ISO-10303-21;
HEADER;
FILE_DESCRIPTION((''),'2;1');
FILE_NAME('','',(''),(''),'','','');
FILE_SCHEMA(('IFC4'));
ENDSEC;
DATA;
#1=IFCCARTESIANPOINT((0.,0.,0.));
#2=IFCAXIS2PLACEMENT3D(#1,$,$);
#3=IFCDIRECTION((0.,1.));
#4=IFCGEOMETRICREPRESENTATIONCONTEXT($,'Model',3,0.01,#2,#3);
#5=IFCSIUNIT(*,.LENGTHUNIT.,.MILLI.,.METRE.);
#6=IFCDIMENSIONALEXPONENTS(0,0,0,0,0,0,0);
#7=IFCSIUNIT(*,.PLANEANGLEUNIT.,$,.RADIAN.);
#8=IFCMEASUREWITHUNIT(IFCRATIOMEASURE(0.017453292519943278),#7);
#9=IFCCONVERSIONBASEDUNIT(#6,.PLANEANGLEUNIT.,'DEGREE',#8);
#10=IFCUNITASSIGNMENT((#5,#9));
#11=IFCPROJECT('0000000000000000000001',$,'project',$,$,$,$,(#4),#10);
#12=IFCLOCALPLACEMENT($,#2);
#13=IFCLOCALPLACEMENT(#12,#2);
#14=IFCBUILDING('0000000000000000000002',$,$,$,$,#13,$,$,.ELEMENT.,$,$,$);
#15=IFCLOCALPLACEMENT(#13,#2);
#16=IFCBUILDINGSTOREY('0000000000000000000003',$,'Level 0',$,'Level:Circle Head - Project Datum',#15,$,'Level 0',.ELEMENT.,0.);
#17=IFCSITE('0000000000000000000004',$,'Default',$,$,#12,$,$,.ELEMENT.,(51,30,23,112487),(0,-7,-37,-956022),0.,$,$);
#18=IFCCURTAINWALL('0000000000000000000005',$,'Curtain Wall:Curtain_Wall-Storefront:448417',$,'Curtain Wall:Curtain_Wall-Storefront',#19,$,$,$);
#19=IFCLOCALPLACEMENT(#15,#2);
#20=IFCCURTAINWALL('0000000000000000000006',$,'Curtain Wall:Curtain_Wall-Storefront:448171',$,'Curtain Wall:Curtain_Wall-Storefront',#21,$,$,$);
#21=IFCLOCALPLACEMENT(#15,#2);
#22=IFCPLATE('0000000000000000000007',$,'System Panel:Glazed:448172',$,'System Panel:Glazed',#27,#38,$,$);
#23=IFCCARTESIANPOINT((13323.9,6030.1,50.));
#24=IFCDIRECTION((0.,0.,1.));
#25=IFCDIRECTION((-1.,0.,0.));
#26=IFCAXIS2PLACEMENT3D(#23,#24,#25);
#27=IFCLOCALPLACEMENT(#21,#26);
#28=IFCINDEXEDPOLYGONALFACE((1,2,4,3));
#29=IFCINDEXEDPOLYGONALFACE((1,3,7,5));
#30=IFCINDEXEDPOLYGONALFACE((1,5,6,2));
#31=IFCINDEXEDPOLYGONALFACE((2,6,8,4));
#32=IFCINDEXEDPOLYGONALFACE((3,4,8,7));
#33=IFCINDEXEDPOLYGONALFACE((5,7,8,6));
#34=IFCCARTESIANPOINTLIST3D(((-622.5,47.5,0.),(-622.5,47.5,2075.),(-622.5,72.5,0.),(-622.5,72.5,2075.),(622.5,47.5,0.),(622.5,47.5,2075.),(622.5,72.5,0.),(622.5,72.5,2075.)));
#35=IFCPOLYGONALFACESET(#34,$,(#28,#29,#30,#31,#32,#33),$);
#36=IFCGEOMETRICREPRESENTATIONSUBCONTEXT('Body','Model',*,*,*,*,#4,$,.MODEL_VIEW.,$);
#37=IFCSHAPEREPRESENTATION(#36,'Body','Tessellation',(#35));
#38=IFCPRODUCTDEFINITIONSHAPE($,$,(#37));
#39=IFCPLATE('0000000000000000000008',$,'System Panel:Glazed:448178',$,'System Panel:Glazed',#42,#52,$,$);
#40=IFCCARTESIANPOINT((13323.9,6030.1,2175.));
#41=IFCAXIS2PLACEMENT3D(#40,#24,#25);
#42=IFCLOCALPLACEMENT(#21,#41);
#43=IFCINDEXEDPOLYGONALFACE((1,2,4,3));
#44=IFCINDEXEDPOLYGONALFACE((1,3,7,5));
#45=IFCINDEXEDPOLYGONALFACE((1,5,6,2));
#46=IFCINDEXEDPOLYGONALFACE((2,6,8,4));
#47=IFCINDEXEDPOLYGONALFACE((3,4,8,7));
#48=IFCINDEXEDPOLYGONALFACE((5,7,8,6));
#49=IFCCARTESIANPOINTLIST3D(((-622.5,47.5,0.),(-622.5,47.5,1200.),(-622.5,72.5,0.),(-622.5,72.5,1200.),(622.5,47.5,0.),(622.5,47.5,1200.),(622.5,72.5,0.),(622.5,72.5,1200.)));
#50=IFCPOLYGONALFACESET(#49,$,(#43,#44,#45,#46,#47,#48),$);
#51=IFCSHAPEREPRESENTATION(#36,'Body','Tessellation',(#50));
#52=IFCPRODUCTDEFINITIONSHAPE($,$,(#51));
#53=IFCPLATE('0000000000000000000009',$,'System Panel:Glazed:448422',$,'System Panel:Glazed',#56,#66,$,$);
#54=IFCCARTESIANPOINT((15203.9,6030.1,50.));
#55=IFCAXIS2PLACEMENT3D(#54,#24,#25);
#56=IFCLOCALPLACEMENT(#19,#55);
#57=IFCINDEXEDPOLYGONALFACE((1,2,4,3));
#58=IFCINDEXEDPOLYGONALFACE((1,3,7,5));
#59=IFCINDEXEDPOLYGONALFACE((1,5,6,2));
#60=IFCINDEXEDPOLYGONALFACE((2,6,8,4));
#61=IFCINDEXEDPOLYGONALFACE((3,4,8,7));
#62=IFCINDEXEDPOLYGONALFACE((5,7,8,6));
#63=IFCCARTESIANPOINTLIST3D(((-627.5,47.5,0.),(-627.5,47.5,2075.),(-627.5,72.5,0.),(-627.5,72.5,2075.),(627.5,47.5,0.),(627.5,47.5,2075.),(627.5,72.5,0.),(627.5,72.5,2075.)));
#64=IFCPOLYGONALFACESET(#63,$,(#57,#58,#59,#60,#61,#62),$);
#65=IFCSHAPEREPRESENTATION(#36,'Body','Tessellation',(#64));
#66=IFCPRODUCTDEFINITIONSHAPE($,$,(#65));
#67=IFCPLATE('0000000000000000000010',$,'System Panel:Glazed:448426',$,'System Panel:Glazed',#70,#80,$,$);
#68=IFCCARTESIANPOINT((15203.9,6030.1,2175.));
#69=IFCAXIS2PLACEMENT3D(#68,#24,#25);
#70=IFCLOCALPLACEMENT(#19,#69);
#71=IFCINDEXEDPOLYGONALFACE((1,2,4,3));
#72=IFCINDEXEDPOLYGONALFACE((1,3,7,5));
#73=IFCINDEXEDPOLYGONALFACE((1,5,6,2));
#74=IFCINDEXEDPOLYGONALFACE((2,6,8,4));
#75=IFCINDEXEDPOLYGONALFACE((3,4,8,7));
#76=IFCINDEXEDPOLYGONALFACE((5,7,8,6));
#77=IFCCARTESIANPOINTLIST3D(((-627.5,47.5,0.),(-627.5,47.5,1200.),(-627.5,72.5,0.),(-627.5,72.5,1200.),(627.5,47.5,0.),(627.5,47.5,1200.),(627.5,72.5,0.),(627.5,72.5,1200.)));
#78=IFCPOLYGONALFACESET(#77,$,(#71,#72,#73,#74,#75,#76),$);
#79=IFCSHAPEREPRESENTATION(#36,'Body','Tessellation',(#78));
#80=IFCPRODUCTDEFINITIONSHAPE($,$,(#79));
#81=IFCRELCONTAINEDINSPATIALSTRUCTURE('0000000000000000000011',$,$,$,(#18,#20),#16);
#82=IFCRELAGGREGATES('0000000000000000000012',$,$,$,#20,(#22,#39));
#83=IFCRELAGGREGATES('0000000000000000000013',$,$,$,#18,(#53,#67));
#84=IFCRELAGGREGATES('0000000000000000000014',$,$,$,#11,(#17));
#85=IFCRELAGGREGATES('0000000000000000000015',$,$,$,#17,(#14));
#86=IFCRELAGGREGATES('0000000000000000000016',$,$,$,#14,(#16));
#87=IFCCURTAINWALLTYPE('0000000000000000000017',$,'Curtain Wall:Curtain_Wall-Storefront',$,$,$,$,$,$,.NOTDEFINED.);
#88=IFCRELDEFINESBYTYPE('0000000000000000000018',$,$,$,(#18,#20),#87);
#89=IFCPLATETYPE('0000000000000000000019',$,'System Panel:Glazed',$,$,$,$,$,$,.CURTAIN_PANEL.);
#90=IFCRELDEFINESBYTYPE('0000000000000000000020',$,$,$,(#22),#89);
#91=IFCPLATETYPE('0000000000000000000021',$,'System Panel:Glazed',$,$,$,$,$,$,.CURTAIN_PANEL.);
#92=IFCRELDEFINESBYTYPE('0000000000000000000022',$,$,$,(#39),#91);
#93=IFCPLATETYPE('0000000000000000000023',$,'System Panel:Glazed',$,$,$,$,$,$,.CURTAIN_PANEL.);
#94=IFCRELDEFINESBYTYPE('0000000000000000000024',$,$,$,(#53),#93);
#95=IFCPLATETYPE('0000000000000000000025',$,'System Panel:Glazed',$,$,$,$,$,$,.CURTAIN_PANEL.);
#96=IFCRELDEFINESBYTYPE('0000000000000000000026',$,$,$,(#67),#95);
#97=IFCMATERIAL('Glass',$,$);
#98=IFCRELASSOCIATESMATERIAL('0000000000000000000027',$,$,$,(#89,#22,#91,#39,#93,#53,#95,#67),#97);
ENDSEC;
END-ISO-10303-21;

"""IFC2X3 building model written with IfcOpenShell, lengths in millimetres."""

from ifc_helpers import new_model, entity, si_unit, converted_unit, direction, frame, origin, origin_2d_with_axis, place, context, subcontext, project, spatial, rectangle, extrude, source, transform, mapped, material, type_object, type_shapes, element, aggregate, save


model = new_model("IFC2X3")

# Units and contexts
model_context = context("Model", 3, precision=0.01, world=origin(), true_north=direction((0.0, 1.0)))
body_context = subcontext(model_context, "Body", "Model", "MODEL_VIEW")
ifc_project = project(units=[si_unit("LENGTHUNIT", "METRE", prefix="MILLI"), converted_unit("PLANEANGLEUNIT", "DEGREE", entity("IfcRatioMeasure", 0.017453292519943278), si_unit("PLANEANGLEUNIT", "RADIAN"), dimensions=[0, 0, 0, 0, 0, 0, 0])], contexts=[model_context])

# Site, building, storey
site_placement = place(None, origin())
site = spatial("IfcSite", under=ifc_project, at=site_placement, Name="Default", CompositionType="ELEMENT", RefLatitude=(51, 30, 23, 112487), RefLongitude=(0, -7, -37, -956022), RefElevation=0.0)
building_placement = place(site_placement, origin())
building = spatial("IfcBuilding", under=site, at=building_placement, CompositionType="ELEMENT")
storey_placement = place(building_placement, origin())
storey = spatial("IfcBuildingStorey", under=building, at=storey_placement, Name="Level 0", ObjectType="Level:Circle Head - Project Datum", LongName="Level 0", CompositionType="ELEMENT", Elevation=0.0)

# Curtain walls
curtain_wall_type = type_object("IfcCurtainWallType", Name="Curtain Wall:Curtain_Wall-Storefront", PredefinedType="NOTDEFINED")
curtain_wall_1_placement = place(storey_placement, origin())
curtain_wall_1 = element("IfcCurtainWall", 1, at=curtain_wall_1_placement, inside=storey, type_object=curtain_wall_type, Name="Curtain Wall:Curtain_Wall-Storefront:448417", ObjectType="Curtain Wall:Curtain_Wall-Storefront")
curtain_wall_2_placement = place(storey_placement, origin())
curtain_wall_2 = element("IfcCurtainWall", 2, at=curtain_wall_2_placement, inside=storey, type_object=curtain_wall_type, Name="Curtain Wall:Curtain_Wall-Storefront:448171", ObjectType="Curtain Wall:Curtain_Wall-Storefront")

# Plates
ifc_material_1 = material(Name="Glass")
plate_type_1 = type_object("IfcPlateType", Name="System Panel:Glazed", PredefinedType="CURTAIN_PANEL", material=ifc_material_1)
shared_shape_1 = source(origin(), body_context, "Body", "SweptSolid", [
    extrude(rectangle(XDim=25.0, YDim=1245.0, at=origin_2d_with_axis()), frame((0.0, 60.0, 0.0), z_axis=(0.0, 0.0, 1.0), x_axis=(0.0, 1.0, 0.0)), (0.0, 0.0, 1.0), 2075.0),
])
type_shapes(plate_type_1, [shared_shape_1])
plate_1_placement = place(curtain_wall_2_placement, frame((13323.9, 6030.1, 50.0), z_axis=(0.0, 0.0, 1.0), x_axis=(-1.0, 0.0, 0.0)))
plate_1 = element("IfcPlate", 3, at=plate_1_placement, type_object=plate_type_1, material=ifc_material_1, Name="System Panel:Glazed:448172", ObjectType="System Panel:Glazed", context=body_context, shape_type="MappedRepresentation", body=[
    mapped(shared_shape_1, transform((0.0, 0.0, 0.0), scale=1.0)),
])
plate_type_2 = type_object("IfcPlateType", Name="System Panel:Glazed", PredefinedType="CURTAIN_PANEL", material=ifc_material_1)
shared_shape_2 = source(origin(), body_context, "Body", "SweptSolid", [
    extrude(rectangle(XDim=25.0, YDim=1245.0, at=origin_2d_with_axis()), frame((0.0, 60.0, 0.0), z_axis=(0.0, 0.0, 1.0), x_axis=(0.0, 1.0, 0.0)), (0.0, 0.0, 1.0), 1200.0),
])
type_shapes(plate_type_2, [shared_shape_2])
plate_2_placement = place(curtain_wall_2_placement, frame((13323.9, 6030.1, 2175.0), z_axis=(0.0, 0.0, 1.0), x_axis=(-1.0, 0.0, 0.0)))
plate_2 = element("IfcPlate", 4, at=plate_2_placement, type_object=plate_type_2, material=ifc_material_1, Name="System Panel:Glazed:448178", ObjectType="System Panel:Glazed", context=body_context, shape_type="MappedRepresentation", body=[
    mapped(shared_shape_2, transform((0.0, 0.0, 0.0), scale=1.0)),
])
aggregate(curtain_wall_2, [plate_1, plate_2])
plate_type_3 = type_object("IfcPlateType", Name="System Panel:Glazed", PredefinedType="CURTAIN_PANEL", material=ifc_material_1)
shared_shape_3 = source(origin(), body_context, "Body", "SweptSolid", [
    extrude(rectangle(XDim=25.0, YDim=1255.0, at=origin_2d_with_axis()), frame((0.0, 60.0, 0.0), z_axis=(0.0, 0.0, 1.0), x_axis=(0.0, 1.0, 0.0)), (0.0, 0.0, 1.0), 2075.0),
])
type_shapes(plate_type_3, [shared_shape_3])
plate_3_placement = place(curtain_wall_1_placement, frame((15203.9, 6030.1, 50.0), z_axis=(0.0, 0.0, 1.0), x_axis=(-1.0, 0.0, 0.0)))
plate_3 = element("IfcPlate", 5, at=plate_3_placement, type_object=plate_type_3, material=ifc_material_1, Name="System Panel:Glazed:448422", ObjectType="System Panel:Glazed", context=body_context, shape_type="MappedRepresentation", body=[
    mapped(shared_shape_3, transform((0.0, 0.0, 0.0), scale=1.0)),
])
plate_type_4 = type_object("IfcPlateType", Name="System Panel:Glazed", PredefinedType="CURTAIN_PANEL", material=ifc_material_1)
shared_shape_4 = source(origin(), body_context, "Body", "SweptSolid", [
    extrude(rectangle(XDim=25.0, YDim=1255.0, at=origin_2d_with_axis()), frame((0.0, 60.0, 0.0), z_axis=(0.0, 0.0, 1.0), x_axis=(0.0, 1.0, 0.0)), (0.0, 0.0, 1.0), 1200.0),
])
type_shapes(plate_type_4, [shared_shape_4])
plate_4_placement = place(curtain_wall_1_placement, frame((15203.9, 6030.1, 2175.0), z_axis=(0.0, 0.0, 1.0), x_axis=(-1.0, 0.0, 0.0)))
plate_4 = element("IfcPlate", 6, at=plate_4_placement, type_object=plate_type_4, material=ifc_material_1, Name="System Panel:Glazed:448426", ObjectType="System Panel:Glazed", context=body_context, shape_type="MappedRepresentation", body=[
    mapped(shared_shape_4, transform((0.0, 0.0, 0.0), scale=1.0)),
])
aggregate(curtain_wall_1, [plate_3, plate_4])

save(model, "model.ifc")
